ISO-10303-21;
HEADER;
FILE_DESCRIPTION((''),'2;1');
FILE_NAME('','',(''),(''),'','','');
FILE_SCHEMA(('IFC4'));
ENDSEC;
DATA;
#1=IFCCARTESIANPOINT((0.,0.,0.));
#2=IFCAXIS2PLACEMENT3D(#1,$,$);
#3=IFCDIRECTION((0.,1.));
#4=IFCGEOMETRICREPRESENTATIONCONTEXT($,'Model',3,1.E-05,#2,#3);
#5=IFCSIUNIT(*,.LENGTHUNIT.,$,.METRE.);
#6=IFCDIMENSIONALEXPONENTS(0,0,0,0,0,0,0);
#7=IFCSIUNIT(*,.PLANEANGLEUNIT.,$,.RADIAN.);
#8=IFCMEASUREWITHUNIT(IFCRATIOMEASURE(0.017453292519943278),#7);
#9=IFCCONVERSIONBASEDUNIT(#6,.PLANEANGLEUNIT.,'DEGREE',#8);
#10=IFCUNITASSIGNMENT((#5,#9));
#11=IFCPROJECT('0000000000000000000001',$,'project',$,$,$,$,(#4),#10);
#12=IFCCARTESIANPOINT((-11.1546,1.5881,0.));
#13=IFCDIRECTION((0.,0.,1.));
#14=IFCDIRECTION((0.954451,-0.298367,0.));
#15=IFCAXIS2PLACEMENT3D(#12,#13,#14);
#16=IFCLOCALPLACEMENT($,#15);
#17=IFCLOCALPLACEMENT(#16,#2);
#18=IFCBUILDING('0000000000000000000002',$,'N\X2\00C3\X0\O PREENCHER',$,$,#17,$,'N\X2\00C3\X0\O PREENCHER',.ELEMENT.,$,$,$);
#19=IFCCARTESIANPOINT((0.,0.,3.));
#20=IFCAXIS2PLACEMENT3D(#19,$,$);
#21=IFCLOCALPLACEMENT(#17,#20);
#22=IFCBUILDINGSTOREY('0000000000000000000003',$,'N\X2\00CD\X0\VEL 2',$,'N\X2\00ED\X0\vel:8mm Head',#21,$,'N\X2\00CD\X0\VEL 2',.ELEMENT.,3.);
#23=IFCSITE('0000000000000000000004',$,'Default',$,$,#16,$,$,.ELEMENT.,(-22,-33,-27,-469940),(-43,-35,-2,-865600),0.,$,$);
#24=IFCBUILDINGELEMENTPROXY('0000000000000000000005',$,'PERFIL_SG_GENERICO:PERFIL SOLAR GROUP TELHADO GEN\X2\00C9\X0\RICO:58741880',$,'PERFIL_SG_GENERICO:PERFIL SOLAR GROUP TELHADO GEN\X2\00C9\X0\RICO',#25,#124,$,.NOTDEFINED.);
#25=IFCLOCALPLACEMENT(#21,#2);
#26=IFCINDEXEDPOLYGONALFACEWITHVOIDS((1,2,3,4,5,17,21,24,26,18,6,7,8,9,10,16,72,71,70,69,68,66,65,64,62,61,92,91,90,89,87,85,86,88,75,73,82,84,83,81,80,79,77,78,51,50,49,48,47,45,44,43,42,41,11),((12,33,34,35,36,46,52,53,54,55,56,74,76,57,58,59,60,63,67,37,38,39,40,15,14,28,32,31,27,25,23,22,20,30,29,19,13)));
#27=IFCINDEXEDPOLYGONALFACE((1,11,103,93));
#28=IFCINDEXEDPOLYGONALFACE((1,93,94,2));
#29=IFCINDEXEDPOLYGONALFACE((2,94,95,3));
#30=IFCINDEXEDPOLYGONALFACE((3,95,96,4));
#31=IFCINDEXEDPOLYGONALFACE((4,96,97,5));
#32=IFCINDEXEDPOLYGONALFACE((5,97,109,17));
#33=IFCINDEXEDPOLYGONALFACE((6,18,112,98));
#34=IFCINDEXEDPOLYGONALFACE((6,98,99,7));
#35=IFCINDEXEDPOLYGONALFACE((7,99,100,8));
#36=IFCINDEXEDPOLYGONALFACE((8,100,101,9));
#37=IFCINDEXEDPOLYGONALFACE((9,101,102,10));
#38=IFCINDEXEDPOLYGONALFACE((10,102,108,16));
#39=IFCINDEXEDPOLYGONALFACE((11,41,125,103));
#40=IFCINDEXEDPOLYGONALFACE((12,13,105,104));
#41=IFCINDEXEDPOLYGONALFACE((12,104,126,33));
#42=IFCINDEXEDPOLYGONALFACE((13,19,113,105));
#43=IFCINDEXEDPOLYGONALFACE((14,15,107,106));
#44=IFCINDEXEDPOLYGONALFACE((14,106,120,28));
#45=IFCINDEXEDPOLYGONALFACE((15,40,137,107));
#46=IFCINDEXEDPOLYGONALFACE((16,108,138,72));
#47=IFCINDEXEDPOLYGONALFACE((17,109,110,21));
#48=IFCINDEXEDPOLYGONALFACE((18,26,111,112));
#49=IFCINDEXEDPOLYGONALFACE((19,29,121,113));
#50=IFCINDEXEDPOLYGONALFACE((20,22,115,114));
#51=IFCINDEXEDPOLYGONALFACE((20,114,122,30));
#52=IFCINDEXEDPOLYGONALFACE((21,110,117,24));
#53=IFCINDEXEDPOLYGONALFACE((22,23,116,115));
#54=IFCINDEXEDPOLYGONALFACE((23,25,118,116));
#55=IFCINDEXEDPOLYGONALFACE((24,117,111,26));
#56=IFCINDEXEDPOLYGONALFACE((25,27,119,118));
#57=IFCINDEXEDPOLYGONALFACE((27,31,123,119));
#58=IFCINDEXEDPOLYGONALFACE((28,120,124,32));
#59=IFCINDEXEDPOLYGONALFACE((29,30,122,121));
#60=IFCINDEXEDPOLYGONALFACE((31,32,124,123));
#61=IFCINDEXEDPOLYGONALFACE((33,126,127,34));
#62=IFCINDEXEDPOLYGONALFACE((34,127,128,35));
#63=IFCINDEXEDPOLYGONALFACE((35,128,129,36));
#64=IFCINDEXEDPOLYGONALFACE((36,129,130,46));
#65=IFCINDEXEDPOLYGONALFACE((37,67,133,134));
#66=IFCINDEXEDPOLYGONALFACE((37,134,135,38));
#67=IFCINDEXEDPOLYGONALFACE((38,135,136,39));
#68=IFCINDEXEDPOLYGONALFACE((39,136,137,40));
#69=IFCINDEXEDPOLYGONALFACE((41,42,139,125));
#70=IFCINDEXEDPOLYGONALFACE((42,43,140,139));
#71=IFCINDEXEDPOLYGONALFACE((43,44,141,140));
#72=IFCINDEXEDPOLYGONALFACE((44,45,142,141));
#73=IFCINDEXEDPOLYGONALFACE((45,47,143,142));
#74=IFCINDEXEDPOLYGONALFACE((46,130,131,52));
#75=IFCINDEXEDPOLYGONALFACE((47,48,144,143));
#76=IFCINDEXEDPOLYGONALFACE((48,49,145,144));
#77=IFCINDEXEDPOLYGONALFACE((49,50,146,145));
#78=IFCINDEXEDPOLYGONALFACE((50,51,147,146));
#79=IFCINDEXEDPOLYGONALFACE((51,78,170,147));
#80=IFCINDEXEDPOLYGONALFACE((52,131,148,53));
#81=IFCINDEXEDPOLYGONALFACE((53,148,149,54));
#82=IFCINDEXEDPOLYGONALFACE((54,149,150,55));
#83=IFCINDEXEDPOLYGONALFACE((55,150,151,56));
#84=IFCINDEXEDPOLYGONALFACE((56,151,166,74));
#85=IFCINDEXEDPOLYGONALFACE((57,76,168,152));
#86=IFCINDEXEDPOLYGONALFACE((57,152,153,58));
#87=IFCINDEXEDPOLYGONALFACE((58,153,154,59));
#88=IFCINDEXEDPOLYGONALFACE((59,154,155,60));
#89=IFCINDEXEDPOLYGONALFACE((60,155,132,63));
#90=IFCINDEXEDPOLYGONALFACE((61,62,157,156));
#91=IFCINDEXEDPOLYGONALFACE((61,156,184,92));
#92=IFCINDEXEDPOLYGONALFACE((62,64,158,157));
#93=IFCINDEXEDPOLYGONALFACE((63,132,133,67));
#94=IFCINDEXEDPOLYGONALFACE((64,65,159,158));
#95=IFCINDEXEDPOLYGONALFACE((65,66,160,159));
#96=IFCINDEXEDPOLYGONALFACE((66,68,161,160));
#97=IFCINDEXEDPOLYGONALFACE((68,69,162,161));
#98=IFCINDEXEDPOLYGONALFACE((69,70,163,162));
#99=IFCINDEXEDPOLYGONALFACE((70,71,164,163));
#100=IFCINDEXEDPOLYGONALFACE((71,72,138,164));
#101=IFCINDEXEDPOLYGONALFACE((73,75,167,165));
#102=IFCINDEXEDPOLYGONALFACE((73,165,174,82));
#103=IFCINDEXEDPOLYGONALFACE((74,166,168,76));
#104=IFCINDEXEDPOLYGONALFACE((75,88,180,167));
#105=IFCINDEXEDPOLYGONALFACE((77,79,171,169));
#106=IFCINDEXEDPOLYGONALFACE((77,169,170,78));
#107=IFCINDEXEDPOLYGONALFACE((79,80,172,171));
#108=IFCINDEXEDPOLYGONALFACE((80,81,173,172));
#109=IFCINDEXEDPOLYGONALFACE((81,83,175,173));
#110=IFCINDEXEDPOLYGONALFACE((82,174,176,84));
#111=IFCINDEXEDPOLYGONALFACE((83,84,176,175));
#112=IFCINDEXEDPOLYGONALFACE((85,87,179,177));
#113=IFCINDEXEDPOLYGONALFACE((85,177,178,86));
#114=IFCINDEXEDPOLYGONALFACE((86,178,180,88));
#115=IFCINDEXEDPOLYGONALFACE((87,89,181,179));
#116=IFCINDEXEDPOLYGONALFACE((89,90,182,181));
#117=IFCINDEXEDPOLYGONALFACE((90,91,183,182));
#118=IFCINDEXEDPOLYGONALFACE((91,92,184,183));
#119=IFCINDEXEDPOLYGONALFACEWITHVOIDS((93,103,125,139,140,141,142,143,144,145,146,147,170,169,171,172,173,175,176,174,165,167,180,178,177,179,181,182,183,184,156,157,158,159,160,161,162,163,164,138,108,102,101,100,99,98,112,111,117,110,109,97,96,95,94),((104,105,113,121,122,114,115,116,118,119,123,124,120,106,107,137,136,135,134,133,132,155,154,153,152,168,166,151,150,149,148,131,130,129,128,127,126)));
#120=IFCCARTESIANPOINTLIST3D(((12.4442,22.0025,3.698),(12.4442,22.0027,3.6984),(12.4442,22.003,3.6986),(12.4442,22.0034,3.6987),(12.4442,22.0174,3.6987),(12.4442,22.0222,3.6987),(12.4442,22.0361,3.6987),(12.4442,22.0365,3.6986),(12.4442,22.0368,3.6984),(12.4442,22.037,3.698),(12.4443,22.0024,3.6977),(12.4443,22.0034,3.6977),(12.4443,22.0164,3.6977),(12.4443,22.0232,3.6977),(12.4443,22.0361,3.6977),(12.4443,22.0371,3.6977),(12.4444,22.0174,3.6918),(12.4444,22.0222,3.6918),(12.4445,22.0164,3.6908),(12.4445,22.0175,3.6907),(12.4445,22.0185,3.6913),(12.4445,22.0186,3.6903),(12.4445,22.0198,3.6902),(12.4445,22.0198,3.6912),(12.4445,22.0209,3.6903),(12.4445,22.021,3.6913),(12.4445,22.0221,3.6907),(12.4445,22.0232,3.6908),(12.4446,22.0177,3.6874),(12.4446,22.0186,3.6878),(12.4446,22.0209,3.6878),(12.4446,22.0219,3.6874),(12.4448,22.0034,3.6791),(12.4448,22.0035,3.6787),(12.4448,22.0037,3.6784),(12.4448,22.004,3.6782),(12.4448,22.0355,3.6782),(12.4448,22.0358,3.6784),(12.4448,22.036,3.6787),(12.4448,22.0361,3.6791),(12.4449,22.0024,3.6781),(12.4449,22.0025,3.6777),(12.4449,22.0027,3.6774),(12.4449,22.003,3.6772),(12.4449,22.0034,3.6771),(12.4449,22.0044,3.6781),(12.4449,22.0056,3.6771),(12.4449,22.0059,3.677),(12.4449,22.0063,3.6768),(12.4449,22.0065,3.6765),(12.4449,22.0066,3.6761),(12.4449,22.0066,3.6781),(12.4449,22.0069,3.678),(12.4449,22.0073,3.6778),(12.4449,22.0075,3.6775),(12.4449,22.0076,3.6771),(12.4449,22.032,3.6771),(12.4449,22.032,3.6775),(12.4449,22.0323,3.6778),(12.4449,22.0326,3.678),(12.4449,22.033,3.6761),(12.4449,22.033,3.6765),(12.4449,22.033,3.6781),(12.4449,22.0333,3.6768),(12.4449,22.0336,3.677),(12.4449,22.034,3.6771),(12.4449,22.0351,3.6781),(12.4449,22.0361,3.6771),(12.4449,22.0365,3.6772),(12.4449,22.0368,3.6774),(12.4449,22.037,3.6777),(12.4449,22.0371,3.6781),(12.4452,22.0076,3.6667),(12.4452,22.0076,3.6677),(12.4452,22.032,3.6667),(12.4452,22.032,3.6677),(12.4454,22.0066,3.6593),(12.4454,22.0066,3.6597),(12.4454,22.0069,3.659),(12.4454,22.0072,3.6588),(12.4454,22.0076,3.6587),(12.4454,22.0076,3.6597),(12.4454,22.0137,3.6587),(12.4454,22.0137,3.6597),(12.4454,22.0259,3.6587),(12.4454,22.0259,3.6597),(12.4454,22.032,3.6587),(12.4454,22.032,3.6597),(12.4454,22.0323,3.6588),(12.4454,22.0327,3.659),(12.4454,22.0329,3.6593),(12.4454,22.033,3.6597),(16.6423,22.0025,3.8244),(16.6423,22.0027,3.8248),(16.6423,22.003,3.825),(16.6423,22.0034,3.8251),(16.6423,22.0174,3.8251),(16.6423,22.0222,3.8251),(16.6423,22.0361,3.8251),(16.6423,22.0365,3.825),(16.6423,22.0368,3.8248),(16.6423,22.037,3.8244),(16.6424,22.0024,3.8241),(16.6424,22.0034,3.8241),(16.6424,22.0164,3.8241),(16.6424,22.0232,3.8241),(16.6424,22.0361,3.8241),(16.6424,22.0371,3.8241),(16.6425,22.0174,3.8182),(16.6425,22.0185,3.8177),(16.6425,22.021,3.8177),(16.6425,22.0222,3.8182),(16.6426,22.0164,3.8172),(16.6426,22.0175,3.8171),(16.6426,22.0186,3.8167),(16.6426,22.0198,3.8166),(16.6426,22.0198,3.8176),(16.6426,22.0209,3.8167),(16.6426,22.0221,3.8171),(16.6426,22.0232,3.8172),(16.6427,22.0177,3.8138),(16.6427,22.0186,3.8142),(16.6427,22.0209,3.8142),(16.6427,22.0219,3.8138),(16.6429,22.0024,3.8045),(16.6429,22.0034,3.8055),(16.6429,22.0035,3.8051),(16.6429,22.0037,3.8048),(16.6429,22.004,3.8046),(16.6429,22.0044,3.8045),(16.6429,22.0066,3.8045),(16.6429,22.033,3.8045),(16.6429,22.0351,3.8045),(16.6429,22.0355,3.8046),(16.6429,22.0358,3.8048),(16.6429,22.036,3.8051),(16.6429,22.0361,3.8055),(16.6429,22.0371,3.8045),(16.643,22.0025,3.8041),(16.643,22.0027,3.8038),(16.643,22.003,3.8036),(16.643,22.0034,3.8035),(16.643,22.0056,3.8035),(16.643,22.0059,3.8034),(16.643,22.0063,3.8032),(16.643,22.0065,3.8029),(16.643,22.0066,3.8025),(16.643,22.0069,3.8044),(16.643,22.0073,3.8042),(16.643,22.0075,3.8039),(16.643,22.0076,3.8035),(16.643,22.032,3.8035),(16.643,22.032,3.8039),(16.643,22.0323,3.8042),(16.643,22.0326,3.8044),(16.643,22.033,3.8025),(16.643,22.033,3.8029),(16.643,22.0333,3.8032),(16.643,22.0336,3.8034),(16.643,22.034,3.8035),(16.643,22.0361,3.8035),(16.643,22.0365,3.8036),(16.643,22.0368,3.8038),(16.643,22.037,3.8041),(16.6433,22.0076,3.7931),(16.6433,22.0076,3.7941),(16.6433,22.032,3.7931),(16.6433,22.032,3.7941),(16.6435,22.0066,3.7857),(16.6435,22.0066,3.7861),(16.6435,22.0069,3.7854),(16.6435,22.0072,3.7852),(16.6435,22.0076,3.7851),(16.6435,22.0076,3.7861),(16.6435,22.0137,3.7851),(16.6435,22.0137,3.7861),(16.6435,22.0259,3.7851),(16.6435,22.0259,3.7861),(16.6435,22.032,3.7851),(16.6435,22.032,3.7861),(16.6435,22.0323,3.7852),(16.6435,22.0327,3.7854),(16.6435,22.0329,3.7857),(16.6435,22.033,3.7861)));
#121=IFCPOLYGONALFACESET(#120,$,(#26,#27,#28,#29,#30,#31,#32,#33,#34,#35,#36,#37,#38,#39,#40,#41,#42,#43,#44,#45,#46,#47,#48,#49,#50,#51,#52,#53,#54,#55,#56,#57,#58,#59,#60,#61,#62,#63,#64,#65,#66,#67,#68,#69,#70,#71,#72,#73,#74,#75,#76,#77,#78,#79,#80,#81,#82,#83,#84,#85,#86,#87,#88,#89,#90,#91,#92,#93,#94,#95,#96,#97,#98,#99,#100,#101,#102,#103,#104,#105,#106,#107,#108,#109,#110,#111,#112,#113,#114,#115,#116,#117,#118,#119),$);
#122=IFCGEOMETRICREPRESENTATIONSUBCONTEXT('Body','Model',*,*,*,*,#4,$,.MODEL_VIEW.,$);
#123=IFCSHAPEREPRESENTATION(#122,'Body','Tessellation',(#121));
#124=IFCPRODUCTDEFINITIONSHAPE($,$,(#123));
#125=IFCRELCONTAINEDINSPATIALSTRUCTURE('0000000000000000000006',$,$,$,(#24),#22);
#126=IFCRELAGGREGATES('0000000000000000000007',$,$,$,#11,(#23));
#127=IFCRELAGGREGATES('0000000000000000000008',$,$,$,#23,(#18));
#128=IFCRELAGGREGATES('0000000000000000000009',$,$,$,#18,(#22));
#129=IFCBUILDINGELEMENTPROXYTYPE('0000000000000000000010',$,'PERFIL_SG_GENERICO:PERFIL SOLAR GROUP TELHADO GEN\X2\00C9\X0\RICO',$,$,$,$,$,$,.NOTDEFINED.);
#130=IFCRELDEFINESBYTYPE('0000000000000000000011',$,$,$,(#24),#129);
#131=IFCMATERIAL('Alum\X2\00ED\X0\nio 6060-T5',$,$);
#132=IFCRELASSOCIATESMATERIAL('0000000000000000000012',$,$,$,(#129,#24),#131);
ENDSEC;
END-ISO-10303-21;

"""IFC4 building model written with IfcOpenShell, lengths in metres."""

from ifc_helpers import new_model, entity, si_unit, converted_unit, direction, frame, origin, place, context, subcontext, project, spatial, line, arc, indexed_curve, outline, extrude, source, transform, mapped, material, type_object, type_shapes, element, save


model = new_model("IFC4")

# Units and contexts
model_context = context("Model", 3, precision=1e-05, world=origin(), true_north=direction((0.0, 1.0)))
body_context = subcontext(model_context, "Body", "Model", "MODEL_VIEW")
ifc_project = project(units=[si_unit("LENGTHUNIT", "METRE"), converted_unit("PLANEANGLEUNIT", "DEGREE", entity("IfcRatioMeasure", 0.017453292519943278), si_unit("PLANEANGLEUNIT", "RADIAN"), dimensions=[0, 0, 0, 0, 0, 0, 0])], contexts=[model_context])

# Site, building, storey
site_placement = place(None, frame((-11.1546, 1.5881, 0.0), z_axis=(0.0, 0.0, 1.0), x_axis=(0.954451, -0.298367, 0.0)))
site = spatial("IfcSite", under=ifc_project, at=site_placement, Name="Default", CompositionType="ELEMENT", RefLatitude=(-22, -33, -27, -469940), RefLongitude=(-43, -35, -2, -865600), RefElevation=0.0)
building_placement = place(site_placement, origin())
building = spatial("IfcBuilding", under=site, at=building_placement, Name="NÃO PREENCHER", LongName="NÃO PREENCHER", CompositionType="ELEMENT")
storey_placement = place(building_placement, frame((0.0, 0.0, 3.0)))
storey = spatial("IfcBuildingStorey", under=building, at=storey_placement, Name="NÍVEL 2", ObjectType="Nível:8mm Head", LongName="NÍVEL 2", CompositionType="ELEMENT", Elevation=3.0)

# Building element proxy
ifc_material_1 = material(Name="Alumínio 6060-T5")
building_element_proxy_type_1 = type_object("IfcBuildingElementProxyType", Name="PERFIL_SG_GENERICO:PERFIL SOLAR GROUP TELHADO GENÉRICO", PredefinedType="NOTDEFINED", material=ifc_material_1)
shared_shape_1 = source(origin(), body_context, "Body", "SweptSolid", [
    extrude(outline(indexed_curve([(-0.0122, -0.0169), (-0.0061, -0.0169), (-0.0061, -0.0159), (-0.0122, -0.0159), (-0.0122, -0.0089), (0.0122, -0.0089), (0.0122, -0.0159), (0.0061, -0.0159), (0.0061, -0.0169), (0.0122, -0.0169), (0.0129, -0.0166), (0.0132, -0.0159), (0.0132, 0.0005), (0.0135, 0.0012), (0.0142, 0.0015), (0.0164, 0.0015), (0.0171, 0.0018), (0.0174, 0.0025), (0.0174, 0.0221), (0.0171, 0.0228), (0.0164, 0.0231), (0.0024, 0.0231), (0.0024, 0.0162), (0.0, 0.0156), (-0.0024, 0.0162), (-0.0024, 0.0231), (-0.0164, 0.0231), (-0.0171, 0.0228), (-0.0174, 0.0221), (-0.0174, 0.0025), (-0.0171, 0.0018), (-0.0164, 0.0015), (-0.0142, 0.0015), (-0.0135, 0.0012), (-0.0132, 0.0005), (-0.0132, -0.0159), (-0.0129, -0.0166)], segments=[line(1, 2, 3, 4, 5, 6, 7, 8, 9, 10), arc(10, 11, 12), line(12, 13), arc(13, 14, 15), line(15, 16), arc(16, 17, 18), line(18, 19), arc(19, 20, 21), line(21, 22, 23), arc(23, 24, 25), line(25, 26, 27), arc(27, 28, 29), line(29, 30), arc(30, 31, 32), line(32, 33), arc(33, 34, 35), line(35, 36), arc(36, 37, 1)], self_intersect=False), holes=[indexed_curve([(-0.0122, -0.0079), (-0.0122, 0.0015), (-0.0125, 0.0022), (-0.0132, 0.0025), (-0.0154, 0.0025), (-0.0161, 0.0028), (-0.0164, 0.0035), (-0.0164, 0.0221), (-0.0034, 0.0221), (-0.0034, 0.0152), (-0.0021, 0.0118), (-0.0012, 0.0122), (-0.0023, 0.0151), (0.0, 0.0146), (0.0023, 0.0151), (0.0012, 0.0122), (0.0021, 0.0118), (0.0034, 0.0152), (0.0034, 0.0221), (0.0164, 0.0221), (0.0164, 0.0035), (0.0161, 0.0028), (0.0154, 0.0025), (0.0132, 0.0025), (0.0125, 0.0022), (0.0122, 0.0015), (0.0122, -0.0079)], segments=[line(1, 2), arc(2, 3, 4), line(4, 5), arc(5, 6, 7), line(7, 8, 9, 10, 11, 12, 13), arc(13, 14, 15), line(15, 16, 17, 18, 19, 20, 21), arc(21, 22, 23), line(23, 24), arc(24, 25, 26), line(26, 27, 1)], self_intersect=False)]), frame((0.0, 0.0, 0.0169), z_axis=(1.0, 0.0, 0.0), x_axis=(0.0, 1.0, 0.0)), (0.0, 0.0, 1.0), 4.2),
])
type_shapes(building_element_proxy_type_1, [shared_shape_1])
for number, where, z_axis, x_axis, name in (
    (1, (12.4454, 22.0198, 3.6587), (-0.030095, 0.0, 0.999547), (0.999547, 0.0, 0.030095), "PERFIL_SG_GENERICO:PERFIL SOLAR GROUP TELHADO GENÉRICO:58741880"),
):
    element("IfcBuildingElementProxy", number, at=place(storey_placement, frame(where, z_axis=z_axis, x_axis=x_axis)), inside=storey, type_object=building_element_proxy_type_1, material=ifc_material_1, Name=name, ObjectType="PERFIL_SG_GENERICO:PERFIL SOLAR GROUP TELHADO GENÉRICO", PredefinedType="NOTDEFINED", context=body_context, shape_type="MappedRepresentation", body=[
        mapped(shared_shape_1, transform((0.0, 0.0, 0.0), scale=1.0)),
    ])

save(model, "model.ifc")
